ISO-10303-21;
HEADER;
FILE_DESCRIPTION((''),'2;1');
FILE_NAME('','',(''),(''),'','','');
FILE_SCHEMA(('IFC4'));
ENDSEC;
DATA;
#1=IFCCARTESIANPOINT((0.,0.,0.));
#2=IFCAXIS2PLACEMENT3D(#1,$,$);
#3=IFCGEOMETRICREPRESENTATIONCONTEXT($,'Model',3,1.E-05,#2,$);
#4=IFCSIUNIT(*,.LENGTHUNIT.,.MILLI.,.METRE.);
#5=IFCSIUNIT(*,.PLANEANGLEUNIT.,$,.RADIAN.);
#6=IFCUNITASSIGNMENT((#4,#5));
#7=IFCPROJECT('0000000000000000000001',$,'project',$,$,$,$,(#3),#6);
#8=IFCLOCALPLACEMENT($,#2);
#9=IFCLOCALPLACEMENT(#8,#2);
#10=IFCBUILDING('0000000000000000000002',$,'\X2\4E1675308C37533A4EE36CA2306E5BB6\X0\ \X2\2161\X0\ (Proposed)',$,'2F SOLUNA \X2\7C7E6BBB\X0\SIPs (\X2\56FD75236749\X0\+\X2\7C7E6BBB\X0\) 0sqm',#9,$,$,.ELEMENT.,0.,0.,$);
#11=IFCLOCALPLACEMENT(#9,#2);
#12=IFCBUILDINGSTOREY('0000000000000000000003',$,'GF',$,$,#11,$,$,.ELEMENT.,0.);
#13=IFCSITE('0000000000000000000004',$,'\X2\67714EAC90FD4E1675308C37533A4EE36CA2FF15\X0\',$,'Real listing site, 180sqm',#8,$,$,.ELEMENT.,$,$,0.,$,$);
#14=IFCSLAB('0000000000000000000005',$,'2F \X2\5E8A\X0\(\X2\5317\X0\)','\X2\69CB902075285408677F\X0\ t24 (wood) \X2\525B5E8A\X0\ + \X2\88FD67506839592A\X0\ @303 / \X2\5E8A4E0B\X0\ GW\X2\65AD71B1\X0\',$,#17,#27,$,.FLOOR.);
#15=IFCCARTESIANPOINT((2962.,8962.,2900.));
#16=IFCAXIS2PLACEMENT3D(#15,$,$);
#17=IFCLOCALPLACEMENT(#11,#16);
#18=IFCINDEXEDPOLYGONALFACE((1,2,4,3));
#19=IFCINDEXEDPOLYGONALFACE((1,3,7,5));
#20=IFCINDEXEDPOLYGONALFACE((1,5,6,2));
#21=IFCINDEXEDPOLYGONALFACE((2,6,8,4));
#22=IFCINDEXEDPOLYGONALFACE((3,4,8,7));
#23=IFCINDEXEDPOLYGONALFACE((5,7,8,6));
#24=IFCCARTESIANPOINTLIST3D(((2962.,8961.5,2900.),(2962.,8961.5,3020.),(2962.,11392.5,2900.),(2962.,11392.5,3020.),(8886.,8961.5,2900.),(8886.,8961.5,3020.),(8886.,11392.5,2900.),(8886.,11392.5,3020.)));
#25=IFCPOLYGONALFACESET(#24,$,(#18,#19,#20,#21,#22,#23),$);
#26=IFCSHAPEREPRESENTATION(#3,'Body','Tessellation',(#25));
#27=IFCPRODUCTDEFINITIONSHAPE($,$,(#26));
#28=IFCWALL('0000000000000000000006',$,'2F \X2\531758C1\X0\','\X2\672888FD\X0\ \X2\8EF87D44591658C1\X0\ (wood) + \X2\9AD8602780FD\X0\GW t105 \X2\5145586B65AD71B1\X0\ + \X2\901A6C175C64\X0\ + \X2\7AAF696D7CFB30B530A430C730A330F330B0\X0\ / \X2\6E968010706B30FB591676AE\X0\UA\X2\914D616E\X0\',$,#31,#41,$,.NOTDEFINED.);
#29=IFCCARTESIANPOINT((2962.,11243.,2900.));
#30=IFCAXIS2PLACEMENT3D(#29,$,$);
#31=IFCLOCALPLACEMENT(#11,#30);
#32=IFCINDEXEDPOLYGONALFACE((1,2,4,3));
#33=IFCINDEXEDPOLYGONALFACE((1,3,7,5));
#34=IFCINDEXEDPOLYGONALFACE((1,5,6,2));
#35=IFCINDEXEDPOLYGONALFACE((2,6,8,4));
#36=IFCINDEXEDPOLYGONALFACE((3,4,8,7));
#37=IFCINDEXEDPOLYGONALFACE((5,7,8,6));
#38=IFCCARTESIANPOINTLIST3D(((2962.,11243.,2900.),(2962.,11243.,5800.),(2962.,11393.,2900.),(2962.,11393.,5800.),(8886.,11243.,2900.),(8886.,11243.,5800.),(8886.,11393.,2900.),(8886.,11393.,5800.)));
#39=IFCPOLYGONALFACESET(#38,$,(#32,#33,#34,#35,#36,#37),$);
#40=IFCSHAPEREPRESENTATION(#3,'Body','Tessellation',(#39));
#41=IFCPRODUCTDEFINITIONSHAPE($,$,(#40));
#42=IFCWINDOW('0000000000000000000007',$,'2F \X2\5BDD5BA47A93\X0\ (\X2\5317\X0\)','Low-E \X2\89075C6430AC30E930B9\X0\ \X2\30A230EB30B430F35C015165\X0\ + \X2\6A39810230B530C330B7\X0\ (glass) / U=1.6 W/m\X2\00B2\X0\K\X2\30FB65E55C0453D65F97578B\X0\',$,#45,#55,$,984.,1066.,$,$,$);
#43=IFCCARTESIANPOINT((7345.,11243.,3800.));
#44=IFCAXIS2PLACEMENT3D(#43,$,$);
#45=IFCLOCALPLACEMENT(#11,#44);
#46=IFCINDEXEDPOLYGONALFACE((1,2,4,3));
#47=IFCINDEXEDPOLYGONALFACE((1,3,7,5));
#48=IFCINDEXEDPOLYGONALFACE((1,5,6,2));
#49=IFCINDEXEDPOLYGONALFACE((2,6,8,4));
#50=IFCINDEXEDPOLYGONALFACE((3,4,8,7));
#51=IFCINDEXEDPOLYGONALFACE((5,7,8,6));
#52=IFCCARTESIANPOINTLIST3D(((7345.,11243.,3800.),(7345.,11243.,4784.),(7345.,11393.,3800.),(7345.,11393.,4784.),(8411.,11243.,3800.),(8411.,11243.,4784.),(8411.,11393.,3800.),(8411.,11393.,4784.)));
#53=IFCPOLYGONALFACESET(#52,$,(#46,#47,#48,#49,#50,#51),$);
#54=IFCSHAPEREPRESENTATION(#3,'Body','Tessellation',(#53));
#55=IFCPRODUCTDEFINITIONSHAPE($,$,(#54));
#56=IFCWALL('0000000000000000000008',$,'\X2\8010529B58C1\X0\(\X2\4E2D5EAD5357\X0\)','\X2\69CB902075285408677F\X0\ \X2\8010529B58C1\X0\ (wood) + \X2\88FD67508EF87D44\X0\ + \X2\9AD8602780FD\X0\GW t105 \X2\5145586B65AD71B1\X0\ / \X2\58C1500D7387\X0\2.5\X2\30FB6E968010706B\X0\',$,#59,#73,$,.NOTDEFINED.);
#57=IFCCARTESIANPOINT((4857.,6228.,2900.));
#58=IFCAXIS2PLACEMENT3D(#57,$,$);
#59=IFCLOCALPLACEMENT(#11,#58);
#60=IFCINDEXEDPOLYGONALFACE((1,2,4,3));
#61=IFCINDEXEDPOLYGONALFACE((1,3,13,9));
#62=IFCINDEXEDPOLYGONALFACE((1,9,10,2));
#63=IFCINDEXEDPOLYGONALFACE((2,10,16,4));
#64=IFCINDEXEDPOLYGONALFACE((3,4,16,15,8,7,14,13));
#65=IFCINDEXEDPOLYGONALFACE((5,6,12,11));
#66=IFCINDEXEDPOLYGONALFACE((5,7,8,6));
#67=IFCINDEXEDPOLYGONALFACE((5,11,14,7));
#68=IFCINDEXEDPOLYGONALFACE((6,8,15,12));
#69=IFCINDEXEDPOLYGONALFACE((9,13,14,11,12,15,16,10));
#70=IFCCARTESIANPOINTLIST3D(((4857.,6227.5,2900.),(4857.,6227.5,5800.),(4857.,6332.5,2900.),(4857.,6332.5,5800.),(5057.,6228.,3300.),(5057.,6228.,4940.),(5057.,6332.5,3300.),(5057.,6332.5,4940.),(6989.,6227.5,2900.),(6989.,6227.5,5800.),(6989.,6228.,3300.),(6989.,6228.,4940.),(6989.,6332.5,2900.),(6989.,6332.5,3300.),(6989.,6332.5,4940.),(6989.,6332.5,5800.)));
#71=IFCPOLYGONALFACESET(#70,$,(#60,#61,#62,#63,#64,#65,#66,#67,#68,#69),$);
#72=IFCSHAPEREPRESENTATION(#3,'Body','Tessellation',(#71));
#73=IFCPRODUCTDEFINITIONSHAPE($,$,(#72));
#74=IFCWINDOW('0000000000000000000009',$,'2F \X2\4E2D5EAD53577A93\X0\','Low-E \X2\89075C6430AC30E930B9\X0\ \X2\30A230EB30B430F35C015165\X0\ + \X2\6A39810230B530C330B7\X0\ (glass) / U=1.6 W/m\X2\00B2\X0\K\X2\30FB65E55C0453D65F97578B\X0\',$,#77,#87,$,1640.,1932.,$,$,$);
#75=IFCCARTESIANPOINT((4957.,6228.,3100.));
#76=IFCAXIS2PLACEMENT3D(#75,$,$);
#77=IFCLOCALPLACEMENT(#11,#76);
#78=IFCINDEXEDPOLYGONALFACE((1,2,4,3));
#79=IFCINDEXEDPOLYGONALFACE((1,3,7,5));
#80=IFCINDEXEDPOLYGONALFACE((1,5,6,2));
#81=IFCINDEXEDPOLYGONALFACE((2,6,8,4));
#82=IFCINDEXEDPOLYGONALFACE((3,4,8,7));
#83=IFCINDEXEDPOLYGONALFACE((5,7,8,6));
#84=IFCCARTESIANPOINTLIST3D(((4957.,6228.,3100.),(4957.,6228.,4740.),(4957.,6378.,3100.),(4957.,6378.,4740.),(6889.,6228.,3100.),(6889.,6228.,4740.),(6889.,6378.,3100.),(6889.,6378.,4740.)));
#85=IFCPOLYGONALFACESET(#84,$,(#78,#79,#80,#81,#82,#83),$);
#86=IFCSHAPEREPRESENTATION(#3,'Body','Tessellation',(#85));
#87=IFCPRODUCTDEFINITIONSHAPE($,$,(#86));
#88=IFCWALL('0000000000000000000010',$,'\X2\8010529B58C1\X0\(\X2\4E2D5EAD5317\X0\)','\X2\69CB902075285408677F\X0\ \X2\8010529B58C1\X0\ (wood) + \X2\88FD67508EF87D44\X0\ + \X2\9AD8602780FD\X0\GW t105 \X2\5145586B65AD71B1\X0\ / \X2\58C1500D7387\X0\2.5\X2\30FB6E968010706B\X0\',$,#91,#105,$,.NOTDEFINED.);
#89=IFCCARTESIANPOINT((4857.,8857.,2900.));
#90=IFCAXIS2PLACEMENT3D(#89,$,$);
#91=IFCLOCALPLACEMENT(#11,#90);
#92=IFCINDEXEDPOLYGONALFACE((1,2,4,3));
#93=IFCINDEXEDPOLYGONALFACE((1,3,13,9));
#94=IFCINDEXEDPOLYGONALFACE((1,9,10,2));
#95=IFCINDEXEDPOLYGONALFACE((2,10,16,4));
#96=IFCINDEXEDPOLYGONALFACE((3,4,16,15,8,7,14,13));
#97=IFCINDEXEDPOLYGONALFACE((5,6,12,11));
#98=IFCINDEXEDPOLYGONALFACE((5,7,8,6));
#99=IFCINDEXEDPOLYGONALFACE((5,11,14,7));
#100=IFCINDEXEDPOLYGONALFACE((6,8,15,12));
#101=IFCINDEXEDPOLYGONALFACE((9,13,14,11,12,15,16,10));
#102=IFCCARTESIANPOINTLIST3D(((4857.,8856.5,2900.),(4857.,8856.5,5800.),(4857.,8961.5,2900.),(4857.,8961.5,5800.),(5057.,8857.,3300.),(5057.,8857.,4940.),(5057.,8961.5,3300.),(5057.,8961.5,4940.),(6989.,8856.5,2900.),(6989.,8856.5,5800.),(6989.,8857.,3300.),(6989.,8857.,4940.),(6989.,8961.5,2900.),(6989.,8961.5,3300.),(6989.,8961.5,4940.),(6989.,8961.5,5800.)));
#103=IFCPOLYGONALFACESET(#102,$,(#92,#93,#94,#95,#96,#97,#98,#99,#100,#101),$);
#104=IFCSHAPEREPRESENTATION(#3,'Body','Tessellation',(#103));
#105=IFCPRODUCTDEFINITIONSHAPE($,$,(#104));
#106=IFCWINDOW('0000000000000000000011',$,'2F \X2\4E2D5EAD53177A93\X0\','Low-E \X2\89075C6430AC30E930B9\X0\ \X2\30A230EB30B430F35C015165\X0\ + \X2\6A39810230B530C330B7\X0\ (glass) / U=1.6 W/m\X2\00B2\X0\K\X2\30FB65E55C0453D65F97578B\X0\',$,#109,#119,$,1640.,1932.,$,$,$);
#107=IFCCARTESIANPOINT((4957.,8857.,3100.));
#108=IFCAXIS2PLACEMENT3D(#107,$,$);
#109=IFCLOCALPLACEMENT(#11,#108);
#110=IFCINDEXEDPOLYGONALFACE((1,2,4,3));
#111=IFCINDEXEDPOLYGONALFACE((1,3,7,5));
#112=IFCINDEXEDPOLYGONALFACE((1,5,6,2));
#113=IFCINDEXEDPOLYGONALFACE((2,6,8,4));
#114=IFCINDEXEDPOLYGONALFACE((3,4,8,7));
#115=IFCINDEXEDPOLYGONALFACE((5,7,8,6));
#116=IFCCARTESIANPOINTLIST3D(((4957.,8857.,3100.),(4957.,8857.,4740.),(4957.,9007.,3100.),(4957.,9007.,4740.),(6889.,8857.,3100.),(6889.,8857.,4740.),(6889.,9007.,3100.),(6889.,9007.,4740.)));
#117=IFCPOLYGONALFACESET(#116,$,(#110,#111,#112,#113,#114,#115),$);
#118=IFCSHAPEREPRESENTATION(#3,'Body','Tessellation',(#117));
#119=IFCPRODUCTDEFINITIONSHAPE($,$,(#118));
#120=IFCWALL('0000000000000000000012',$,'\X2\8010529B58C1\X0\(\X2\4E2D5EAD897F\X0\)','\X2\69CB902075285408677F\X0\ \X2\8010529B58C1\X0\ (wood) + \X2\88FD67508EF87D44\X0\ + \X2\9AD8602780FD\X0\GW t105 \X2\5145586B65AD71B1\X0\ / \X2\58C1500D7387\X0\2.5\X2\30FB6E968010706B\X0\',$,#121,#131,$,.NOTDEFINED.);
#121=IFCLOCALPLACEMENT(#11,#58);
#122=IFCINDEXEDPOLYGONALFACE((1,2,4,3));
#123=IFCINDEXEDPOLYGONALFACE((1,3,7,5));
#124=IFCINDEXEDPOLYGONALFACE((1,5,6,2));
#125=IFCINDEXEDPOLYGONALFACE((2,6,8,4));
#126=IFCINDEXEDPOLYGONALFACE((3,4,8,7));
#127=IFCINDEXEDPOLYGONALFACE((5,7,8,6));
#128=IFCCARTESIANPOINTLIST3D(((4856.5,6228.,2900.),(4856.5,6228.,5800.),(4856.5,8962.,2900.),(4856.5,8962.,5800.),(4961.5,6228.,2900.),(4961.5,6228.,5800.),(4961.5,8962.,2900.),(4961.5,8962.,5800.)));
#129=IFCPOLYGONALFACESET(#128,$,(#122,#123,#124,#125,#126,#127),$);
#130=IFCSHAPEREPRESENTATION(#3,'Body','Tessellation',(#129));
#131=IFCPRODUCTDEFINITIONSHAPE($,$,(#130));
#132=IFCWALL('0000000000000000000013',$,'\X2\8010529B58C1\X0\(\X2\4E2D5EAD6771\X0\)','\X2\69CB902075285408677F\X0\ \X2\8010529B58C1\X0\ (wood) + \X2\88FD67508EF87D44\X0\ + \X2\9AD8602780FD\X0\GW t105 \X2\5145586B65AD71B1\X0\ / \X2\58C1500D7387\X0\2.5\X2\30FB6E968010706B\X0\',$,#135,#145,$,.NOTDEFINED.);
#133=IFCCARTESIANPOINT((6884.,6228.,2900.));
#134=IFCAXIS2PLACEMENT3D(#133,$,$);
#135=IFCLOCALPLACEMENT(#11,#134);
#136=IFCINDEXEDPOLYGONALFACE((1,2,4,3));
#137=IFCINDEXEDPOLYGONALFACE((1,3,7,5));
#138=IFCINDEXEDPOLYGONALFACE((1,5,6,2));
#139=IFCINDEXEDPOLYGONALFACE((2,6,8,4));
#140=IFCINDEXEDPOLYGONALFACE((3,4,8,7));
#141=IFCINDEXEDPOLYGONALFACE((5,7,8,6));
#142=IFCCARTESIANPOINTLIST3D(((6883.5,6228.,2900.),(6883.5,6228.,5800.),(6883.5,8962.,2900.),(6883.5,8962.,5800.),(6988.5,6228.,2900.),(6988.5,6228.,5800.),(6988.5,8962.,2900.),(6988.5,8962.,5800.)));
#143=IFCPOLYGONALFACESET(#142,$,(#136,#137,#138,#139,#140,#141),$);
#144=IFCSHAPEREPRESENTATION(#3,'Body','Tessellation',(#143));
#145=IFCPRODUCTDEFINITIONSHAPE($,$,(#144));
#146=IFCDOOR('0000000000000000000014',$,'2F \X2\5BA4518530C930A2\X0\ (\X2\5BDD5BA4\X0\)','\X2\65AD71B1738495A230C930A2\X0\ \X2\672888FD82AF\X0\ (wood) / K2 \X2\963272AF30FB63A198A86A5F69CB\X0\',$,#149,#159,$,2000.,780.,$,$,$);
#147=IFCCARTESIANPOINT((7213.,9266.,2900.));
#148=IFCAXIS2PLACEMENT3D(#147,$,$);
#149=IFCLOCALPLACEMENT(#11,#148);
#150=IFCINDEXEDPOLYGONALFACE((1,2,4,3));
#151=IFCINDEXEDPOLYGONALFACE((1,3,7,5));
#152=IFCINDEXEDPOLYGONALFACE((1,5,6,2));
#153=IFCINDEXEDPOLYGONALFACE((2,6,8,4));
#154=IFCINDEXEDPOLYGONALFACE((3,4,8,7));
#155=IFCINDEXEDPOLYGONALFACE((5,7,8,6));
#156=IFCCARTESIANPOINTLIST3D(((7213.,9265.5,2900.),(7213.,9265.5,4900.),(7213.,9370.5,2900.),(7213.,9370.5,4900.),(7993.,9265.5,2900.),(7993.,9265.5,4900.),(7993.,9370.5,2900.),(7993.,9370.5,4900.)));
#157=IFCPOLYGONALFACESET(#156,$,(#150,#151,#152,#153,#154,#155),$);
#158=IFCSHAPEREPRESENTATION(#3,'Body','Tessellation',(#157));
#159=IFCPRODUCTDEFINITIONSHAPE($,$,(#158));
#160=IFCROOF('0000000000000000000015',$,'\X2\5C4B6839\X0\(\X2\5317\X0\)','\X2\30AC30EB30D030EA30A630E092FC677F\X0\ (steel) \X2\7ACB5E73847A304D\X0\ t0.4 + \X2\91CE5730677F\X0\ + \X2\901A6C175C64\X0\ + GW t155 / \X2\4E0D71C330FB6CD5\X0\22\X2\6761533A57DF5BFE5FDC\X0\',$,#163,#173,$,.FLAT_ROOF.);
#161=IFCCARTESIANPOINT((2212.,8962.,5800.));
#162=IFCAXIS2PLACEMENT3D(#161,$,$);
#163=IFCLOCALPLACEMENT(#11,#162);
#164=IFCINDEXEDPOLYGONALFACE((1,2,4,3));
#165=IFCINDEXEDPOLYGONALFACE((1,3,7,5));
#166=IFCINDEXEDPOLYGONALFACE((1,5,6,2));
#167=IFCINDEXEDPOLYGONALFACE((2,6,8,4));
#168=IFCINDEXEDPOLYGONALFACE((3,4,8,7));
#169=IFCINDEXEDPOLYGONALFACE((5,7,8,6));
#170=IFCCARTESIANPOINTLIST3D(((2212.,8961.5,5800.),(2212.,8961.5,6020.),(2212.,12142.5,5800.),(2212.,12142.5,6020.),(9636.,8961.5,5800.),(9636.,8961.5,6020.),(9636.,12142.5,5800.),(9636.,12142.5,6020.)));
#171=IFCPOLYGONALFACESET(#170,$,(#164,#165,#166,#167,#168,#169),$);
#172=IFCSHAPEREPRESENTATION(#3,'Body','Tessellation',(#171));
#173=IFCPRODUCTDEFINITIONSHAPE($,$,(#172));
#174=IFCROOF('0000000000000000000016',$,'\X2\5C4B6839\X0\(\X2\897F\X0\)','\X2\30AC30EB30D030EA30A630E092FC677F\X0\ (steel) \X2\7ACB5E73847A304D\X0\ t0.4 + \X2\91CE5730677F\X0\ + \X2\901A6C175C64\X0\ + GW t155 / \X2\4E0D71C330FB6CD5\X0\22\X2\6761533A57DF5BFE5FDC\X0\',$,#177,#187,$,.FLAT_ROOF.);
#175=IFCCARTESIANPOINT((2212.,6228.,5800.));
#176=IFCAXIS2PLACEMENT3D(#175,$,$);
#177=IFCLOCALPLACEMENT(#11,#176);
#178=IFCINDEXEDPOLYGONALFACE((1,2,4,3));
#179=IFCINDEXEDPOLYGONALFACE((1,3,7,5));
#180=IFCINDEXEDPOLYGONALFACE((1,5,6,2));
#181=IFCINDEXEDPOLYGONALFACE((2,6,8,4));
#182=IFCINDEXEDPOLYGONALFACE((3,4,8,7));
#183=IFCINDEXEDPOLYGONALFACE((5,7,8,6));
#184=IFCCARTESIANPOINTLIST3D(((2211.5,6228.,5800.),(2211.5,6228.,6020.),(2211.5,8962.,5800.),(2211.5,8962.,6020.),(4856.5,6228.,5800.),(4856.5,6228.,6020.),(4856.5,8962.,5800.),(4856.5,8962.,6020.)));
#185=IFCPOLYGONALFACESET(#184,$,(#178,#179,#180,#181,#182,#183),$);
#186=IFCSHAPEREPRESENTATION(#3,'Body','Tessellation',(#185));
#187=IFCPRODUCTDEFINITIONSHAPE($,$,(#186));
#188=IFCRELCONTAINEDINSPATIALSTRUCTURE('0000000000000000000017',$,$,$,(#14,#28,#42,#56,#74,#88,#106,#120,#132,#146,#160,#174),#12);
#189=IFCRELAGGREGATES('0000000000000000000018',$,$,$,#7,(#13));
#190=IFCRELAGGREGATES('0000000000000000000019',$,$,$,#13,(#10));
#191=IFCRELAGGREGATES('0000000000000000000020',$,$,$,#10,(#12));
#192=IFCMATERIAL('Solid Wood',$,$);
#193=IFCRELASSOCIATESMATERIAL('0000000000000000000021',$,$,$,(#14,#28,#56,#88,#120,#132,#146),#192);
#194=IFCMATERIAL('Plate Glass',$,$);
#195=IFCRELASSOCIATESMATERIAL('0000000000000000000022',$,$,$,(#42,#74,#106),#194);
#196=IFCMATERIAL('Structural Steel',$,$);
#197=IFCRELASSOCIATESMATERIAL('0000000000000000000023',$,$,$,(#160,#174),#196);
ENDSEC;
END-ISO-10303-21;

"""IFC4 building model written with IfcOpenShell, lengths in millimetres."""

from ifc_helpers import new_model, si_unit, frame, frame_2d, origin, place, context, project, spatial, rectangle, extrude, material, element, fill, save


model = new_model("IFC4")

# Units and contexts
model_context = context("Model", 3, precision=1e-05, world=origin())
ifc_project = project(units=[si_unit("LENGTHUNIT", "METRE", prefix="MILLI"), si_unit("PLANEANGLEUNIT", "RADIAN")], contexts=[model_context])

# Site, building, storey
site_placement = place(None, origin())
site = spatial("IfcSite", under=ifc_project, at=site_placement, Name="東京都世田谷区代沢５", ObjectType="Real listing site, 180sqm", CompositionType="ELEMENT", RefElevation=0.0)
building_placement = place(site_placement, origin())
building = spatial("IfcBuilding", under=site, at=building_placement, Name="世田谷区代沢の家 Ⅱ (Proposed)", ObjectType="2F SOLUNA 籾殻SIPs (国産杉+籾殻) 0sqm", CompositionType="ELEMENT", ElevationOfRefHeight=0.0, ElevationOfTerrain=0.0)
storey_placement = place(building_placement, origin())
storey = spatial("IfcBuildingStorey", under=building, at=storey_placement, Name="GF", CompositionType="ELEMENT", Elevation=0.0)

# Slab
ifc_material_1 = material(Name="Solid Wood")
slab_placement = place(storey_placement, frame((2962.0, 8962.0, 2900.0)))
element("IfcSlab", 1, at=slab_placement, inside=storey, material=ifc_material_1, Name="2F 床(北)", Description="構造用合板 t24 (wood) 剛床 + 製材根太 @303 / 床下 GW断熱", PredefinedType="FLOOR", context=model_context, shape_type="SweptSolid", body=[
    extrude(rectangle(XDim=5924.0, YDim=2431.0, at=frame_2d((2962.0, 1215.0))), frame((2962.0, 8962.0, 2900.0)), (0.0, 0.0, 1.0), 120.0),
])

# Walls, openings, windows
wall_1_placement = place(storey_placement, frame((2962.0, 11243.0, 2900.0)))
wall_1 = element("IfcWall", 2, at=wall_1_placement, inside=storey, material=ifc_material_1, Name="2F 北壁", Description="木製 軸組外壁 (wood) + 高性能GW t105 充填断熱 + 通気層 + 窯業系サイディング / 準耐火・外皮UA配慮", PredefinedType="NOTDEFINED", context=model_context, shape_type="SweptSolid", body=[
    extrude(rectangle(XDim=5924.0, YDim=150.0, at=frame_2d((2962.0, 75.0))), frame((2962.0, 11243.0, 2900.0)), (0.0, 0.0, 1.0), 2900.0),
])
opening_1_placement = place(storey_placement, frame((7345.0, 11243.0, 3800.0)))
opening_1 = element("IfcOpeningElement", 3, at=opening_1_placement, cuts=wall_1, PredefinedType="NOTDEFINED", context=model_context, shape_type="SweptSolid", body=[
    extrude(rectangle(XDim=1066.0, YDim=150.0, at=frame_2d((533.0, 75.0))), frame((7345.0, 11243.0, 3800.0)), (0.0, 0.0, 1.0), 984.0),
])
ifc_material_2 = material(Name="Plate Glass")
window_1_placement = place(storey_placement, frame((7345.0, 11243.0, 3800.0)))
window_1 = element("IfcWindow", 4, at=window_1_placement, inside=storey, material=ifc_material_2, Name="2F 寝室窓 (北)", Description="Low-E 複層ガラス アルゴン封入 + 樹脂サッシ (glass) / U=1.6 W/m²K・日射取得型", OverallHeight=984.0, OverallWidth=1066.0, context=model_context, shape_type="SweptSolid", body=[
    extrude(rectangle(XDim=1066.0, YDim=150.0, at=frame_2d((533.0, 75.0))), frame((7345.0, 11243.0, 3800.0)), (0.0, 0.0, 1.0), 984.0),
])
fill(opening_1, window_1)
wall_2_placement = place(storey_placement, frame((4857.0, 6228.0, 2900.0)))
wall_2 = element("IfcWall", 5, at=wall_2_placement, inside=storey, material=ifc_material_1, Name="耐力壁(中庭南)", Description="構造用合板 耐力壁 (wood) + 製材軸組 + 高性能GW t105 充填断熱 / 壁倍率2.5・準耐火", PredefinedType="NOTDEFINED", context=model_context, shape_type="SweptSolid", body=[
    extrude(rectangle(XDim=2132.0, YDim=105.0, at=frame_2d((1066.0, 52.0))), frame((4857.0, 6228.0, 2900.0)), (0.0, 0.0, 1.0), 2900.0),
])
opening_2_placement = place(storey_placement, frame((4957.0, 6228.0, 3100.0)))
opening_2 = element("IfcOpeningElement", 6, at=opening_2_placement, cuts=wall_2, PredefinedType="NOTDEFINED", context=model_context, shape_type="SweptSolid", body=[
    extrude(rectangle(XDim=1932.0, YDim=150.0, at=frame_2d((966.0, 75.0))), frame((4957.0, 6228.0, 3100.0)), (0.0, 0.0, 1.0), 1640.0),
])
window_2_placement = place(storey_placement, frame((4957.0, 6228.0, 3100.0)))
window_2 = element("IfcWindow", 7, at=window_2_placement, inside=storey, material=ifc_material_2, Name="2F 中庭南窓", Description="Low-E 複層ガラス アルゴン封入 + 樹脂サッシ (glass) / U=1.6 W/m²K・日射取得型", OverallHeight=1640.0, OverallWidth=1932.0, context=model_context, shape_type="SweptSolid", body=[
    extrude(rectangle(XDim=1932.0, YDim=150.0, at=frame_2d((966.0, 75.0))), frame((4957.0, 6228.0, 3100.0)), (0.0, 0.0, 1.0), 1640.0),
])
fill(opening_2, window_2)
wall_3_placement = place(storey_placement, frame((4857.0, 8857.0, 2900.0)))
wall_3 = element("IfcWall", 8, at=wall_3_placement, inside=storey, material=ifc_material_1, Name="耐力壁(中庭北)", Description="構造用合板 耐力壁 (wood) + 製材軸組 + 高性能GW t105 充填断熱 / 壁倍率2.5・準耐火", PredefinedType="NOTDEFINED", context=model_context, shape_type="SweptSolid", body=[
    extrude(rectangle(XDim=2132.0, YDim=105.0, at=frame_2d((1066.0, 52.0))), frame((4857.0, 8857.0, 2900.0)), (0.0, 0.0, 1.0), 2900.0),
])
opening_3_placement = place(storey_placement, frame((4957.0, 8857.0, 3100.0)))
opening_3 = element("IfcOpeningElement", 9, at=opening_3_placement, cuts=wall_3, PredefinedType="NOTDEFINED", context=model_context, shape_type="SweptSolid", body=[
    extrude(rectangle(XDim=1932.0, YDim=150.0, at=frame_2d((966.0, 75.0))), frame((4957.0, 8857.0, 3100.0)), (0.0, 0.0, 1.0), 1640.0),
])
window_3_placement = place(storey_placement, frame((4957.0, 8857.0, 3100.0)))
window_3 = element("IfcWindow", 10, at=window_3_placement, inside=storey, material=ifc_material_2, Name="2F 中庭北窓", Description="Low-E 複層ガラス アルゴン封入 + 樹脂サッシ (glass) / U=1.6 W/m²K・日射取得型", OverallHeight=1640.0, OverallWidth=1932.0, context=model_context, shape_type="SweptSolid", body=[
    extrude(rectangle(XDim=1932.0, YDim=150.0, at=frame_2d((966.0, 75.0))), frame((4957.0, 8857.0, 3100.0)), (0.0, 0.0, 1.0), 1640.0),
])
fill(opening_3, window_3)

# Walls
wall_4_placement = place(storey_placement, frame((4857.0, 6228.0, 2900.0)))
element("IfcWall", 11, at=wall_4_placement, inside=storey, material=ifc_material_1, Name="耐力壁(中庭西)", Description="構造用合板 耐力壁 (wood) + 製材軸組 + 高性能GW t105 充填断熱 / 壁倍率2.5・準耐火", PredefinedType="NOTDEFINED", context=model_context, shape_type="SweptSolid", body=[
    extrude(rectangle(XDim=105.0, YDim=2734.0, at=frame_2d((52.0, 1367.0))), frame((4857.0, 6228.0, 2900.0)), (0.0, 0.0, 1.0), 2900.0),
])
wall_5_placement = place(storey_placement, frame((6884.0, 6228.0, 2900.0)))
element("IfcWall", 12, at=wall_5_placement, inside=storey, material=ifc_material_1, Name="耐力壁(中庭東)", Description="構造用合板 耐力壁 (wood) + 製材軸組 + 高性能GW t105 充填断熱 / 壁倍率2.5・準耐火", PredefinedType="NOTDEFINED", context=model_context, shape_type="SweptSolid", body=[
    extrude(rectangle(XDim=105.0, YDim=2734.0, at=frame_2d((52.0, 1367.0))), frame((6884.0, 6228.0, 2900.0)), (0.0, 0.0, 1.0), 2900.0),
])

# Door
door_placement = place(storey_placement, frame((7213.0, 9266.0, 2900.0)))
element("IfcDoor", 13, at=door_placement, inside=storey, material=ifc_material_1, Name="2F 室内ドア (寝室)", Description="断熱玄関ドア 木製芯 (wood) / K2 防犯・採風機構", OverallHeight=2000.0, OverallWidth=780.0, context=model_context, shape_type="SweptSolid", body=[
    extrude(rectangle(XDim=780.0, YDim=105.0, at=frame_2d((390.0, 52.0))), frame((7213.0, 9266.0, 2900.0)), (0.0, 0.0, 1.0), 2000.0),
])

# Roofs
ifc_material_3 = material(Name="Structural Steel")
for number, where, name in (
    (14, (2212.0, 8962.0, 5800.0), "屋根(北)"),
):
    element("IfcRoof", number, at=place(storey_placement, frame(where)), inside=storey, material=ifc_material_3, Name=name, Description="ガルバリウム鋼板 (steel) 立平葺き t0.4 + 野地板 + 通気層 + GW t155 / 不燃・法22条区域対応", PredefinedType="FLAT_ROOF", context=model_context, shape_type="SweptSolid", body=[
        extrude(rectangle(XDim=7424.0, YDim=3181.0, at=frame_2d((3712.0, 1590.0))), frame((2212.0, 8962.0, 5800.0)), (0.0, 0.0, 1.0), 220.0),
    ])
roof_1_placement = place(storey_placement, frame((2212.0, 6228.0, 5800.0)))
element("IfcRoof", 15, at=roof_1_placement, inside=storey, material=ifc_material_3, Name="屋根(西)", Description="ガルバリウム鋼板 (steel) 立平葺き t0.4 + 野地板 + 通気層 + GW t155 / 不燃・法22条区域対応", PredefinedType="FLAT_ROOF", context=model_context, shape_type="SweptSolid", body=[
    extrude(rectangle(XDim=2645.0, YDim=2734.0, at=frame_2d((1322.0, 1367.0))), frame((2212.0, 6228.0, 5800.0)), (0.0, 0.0, 1.0), 220.0),
])

save(model, "model.ifc")
